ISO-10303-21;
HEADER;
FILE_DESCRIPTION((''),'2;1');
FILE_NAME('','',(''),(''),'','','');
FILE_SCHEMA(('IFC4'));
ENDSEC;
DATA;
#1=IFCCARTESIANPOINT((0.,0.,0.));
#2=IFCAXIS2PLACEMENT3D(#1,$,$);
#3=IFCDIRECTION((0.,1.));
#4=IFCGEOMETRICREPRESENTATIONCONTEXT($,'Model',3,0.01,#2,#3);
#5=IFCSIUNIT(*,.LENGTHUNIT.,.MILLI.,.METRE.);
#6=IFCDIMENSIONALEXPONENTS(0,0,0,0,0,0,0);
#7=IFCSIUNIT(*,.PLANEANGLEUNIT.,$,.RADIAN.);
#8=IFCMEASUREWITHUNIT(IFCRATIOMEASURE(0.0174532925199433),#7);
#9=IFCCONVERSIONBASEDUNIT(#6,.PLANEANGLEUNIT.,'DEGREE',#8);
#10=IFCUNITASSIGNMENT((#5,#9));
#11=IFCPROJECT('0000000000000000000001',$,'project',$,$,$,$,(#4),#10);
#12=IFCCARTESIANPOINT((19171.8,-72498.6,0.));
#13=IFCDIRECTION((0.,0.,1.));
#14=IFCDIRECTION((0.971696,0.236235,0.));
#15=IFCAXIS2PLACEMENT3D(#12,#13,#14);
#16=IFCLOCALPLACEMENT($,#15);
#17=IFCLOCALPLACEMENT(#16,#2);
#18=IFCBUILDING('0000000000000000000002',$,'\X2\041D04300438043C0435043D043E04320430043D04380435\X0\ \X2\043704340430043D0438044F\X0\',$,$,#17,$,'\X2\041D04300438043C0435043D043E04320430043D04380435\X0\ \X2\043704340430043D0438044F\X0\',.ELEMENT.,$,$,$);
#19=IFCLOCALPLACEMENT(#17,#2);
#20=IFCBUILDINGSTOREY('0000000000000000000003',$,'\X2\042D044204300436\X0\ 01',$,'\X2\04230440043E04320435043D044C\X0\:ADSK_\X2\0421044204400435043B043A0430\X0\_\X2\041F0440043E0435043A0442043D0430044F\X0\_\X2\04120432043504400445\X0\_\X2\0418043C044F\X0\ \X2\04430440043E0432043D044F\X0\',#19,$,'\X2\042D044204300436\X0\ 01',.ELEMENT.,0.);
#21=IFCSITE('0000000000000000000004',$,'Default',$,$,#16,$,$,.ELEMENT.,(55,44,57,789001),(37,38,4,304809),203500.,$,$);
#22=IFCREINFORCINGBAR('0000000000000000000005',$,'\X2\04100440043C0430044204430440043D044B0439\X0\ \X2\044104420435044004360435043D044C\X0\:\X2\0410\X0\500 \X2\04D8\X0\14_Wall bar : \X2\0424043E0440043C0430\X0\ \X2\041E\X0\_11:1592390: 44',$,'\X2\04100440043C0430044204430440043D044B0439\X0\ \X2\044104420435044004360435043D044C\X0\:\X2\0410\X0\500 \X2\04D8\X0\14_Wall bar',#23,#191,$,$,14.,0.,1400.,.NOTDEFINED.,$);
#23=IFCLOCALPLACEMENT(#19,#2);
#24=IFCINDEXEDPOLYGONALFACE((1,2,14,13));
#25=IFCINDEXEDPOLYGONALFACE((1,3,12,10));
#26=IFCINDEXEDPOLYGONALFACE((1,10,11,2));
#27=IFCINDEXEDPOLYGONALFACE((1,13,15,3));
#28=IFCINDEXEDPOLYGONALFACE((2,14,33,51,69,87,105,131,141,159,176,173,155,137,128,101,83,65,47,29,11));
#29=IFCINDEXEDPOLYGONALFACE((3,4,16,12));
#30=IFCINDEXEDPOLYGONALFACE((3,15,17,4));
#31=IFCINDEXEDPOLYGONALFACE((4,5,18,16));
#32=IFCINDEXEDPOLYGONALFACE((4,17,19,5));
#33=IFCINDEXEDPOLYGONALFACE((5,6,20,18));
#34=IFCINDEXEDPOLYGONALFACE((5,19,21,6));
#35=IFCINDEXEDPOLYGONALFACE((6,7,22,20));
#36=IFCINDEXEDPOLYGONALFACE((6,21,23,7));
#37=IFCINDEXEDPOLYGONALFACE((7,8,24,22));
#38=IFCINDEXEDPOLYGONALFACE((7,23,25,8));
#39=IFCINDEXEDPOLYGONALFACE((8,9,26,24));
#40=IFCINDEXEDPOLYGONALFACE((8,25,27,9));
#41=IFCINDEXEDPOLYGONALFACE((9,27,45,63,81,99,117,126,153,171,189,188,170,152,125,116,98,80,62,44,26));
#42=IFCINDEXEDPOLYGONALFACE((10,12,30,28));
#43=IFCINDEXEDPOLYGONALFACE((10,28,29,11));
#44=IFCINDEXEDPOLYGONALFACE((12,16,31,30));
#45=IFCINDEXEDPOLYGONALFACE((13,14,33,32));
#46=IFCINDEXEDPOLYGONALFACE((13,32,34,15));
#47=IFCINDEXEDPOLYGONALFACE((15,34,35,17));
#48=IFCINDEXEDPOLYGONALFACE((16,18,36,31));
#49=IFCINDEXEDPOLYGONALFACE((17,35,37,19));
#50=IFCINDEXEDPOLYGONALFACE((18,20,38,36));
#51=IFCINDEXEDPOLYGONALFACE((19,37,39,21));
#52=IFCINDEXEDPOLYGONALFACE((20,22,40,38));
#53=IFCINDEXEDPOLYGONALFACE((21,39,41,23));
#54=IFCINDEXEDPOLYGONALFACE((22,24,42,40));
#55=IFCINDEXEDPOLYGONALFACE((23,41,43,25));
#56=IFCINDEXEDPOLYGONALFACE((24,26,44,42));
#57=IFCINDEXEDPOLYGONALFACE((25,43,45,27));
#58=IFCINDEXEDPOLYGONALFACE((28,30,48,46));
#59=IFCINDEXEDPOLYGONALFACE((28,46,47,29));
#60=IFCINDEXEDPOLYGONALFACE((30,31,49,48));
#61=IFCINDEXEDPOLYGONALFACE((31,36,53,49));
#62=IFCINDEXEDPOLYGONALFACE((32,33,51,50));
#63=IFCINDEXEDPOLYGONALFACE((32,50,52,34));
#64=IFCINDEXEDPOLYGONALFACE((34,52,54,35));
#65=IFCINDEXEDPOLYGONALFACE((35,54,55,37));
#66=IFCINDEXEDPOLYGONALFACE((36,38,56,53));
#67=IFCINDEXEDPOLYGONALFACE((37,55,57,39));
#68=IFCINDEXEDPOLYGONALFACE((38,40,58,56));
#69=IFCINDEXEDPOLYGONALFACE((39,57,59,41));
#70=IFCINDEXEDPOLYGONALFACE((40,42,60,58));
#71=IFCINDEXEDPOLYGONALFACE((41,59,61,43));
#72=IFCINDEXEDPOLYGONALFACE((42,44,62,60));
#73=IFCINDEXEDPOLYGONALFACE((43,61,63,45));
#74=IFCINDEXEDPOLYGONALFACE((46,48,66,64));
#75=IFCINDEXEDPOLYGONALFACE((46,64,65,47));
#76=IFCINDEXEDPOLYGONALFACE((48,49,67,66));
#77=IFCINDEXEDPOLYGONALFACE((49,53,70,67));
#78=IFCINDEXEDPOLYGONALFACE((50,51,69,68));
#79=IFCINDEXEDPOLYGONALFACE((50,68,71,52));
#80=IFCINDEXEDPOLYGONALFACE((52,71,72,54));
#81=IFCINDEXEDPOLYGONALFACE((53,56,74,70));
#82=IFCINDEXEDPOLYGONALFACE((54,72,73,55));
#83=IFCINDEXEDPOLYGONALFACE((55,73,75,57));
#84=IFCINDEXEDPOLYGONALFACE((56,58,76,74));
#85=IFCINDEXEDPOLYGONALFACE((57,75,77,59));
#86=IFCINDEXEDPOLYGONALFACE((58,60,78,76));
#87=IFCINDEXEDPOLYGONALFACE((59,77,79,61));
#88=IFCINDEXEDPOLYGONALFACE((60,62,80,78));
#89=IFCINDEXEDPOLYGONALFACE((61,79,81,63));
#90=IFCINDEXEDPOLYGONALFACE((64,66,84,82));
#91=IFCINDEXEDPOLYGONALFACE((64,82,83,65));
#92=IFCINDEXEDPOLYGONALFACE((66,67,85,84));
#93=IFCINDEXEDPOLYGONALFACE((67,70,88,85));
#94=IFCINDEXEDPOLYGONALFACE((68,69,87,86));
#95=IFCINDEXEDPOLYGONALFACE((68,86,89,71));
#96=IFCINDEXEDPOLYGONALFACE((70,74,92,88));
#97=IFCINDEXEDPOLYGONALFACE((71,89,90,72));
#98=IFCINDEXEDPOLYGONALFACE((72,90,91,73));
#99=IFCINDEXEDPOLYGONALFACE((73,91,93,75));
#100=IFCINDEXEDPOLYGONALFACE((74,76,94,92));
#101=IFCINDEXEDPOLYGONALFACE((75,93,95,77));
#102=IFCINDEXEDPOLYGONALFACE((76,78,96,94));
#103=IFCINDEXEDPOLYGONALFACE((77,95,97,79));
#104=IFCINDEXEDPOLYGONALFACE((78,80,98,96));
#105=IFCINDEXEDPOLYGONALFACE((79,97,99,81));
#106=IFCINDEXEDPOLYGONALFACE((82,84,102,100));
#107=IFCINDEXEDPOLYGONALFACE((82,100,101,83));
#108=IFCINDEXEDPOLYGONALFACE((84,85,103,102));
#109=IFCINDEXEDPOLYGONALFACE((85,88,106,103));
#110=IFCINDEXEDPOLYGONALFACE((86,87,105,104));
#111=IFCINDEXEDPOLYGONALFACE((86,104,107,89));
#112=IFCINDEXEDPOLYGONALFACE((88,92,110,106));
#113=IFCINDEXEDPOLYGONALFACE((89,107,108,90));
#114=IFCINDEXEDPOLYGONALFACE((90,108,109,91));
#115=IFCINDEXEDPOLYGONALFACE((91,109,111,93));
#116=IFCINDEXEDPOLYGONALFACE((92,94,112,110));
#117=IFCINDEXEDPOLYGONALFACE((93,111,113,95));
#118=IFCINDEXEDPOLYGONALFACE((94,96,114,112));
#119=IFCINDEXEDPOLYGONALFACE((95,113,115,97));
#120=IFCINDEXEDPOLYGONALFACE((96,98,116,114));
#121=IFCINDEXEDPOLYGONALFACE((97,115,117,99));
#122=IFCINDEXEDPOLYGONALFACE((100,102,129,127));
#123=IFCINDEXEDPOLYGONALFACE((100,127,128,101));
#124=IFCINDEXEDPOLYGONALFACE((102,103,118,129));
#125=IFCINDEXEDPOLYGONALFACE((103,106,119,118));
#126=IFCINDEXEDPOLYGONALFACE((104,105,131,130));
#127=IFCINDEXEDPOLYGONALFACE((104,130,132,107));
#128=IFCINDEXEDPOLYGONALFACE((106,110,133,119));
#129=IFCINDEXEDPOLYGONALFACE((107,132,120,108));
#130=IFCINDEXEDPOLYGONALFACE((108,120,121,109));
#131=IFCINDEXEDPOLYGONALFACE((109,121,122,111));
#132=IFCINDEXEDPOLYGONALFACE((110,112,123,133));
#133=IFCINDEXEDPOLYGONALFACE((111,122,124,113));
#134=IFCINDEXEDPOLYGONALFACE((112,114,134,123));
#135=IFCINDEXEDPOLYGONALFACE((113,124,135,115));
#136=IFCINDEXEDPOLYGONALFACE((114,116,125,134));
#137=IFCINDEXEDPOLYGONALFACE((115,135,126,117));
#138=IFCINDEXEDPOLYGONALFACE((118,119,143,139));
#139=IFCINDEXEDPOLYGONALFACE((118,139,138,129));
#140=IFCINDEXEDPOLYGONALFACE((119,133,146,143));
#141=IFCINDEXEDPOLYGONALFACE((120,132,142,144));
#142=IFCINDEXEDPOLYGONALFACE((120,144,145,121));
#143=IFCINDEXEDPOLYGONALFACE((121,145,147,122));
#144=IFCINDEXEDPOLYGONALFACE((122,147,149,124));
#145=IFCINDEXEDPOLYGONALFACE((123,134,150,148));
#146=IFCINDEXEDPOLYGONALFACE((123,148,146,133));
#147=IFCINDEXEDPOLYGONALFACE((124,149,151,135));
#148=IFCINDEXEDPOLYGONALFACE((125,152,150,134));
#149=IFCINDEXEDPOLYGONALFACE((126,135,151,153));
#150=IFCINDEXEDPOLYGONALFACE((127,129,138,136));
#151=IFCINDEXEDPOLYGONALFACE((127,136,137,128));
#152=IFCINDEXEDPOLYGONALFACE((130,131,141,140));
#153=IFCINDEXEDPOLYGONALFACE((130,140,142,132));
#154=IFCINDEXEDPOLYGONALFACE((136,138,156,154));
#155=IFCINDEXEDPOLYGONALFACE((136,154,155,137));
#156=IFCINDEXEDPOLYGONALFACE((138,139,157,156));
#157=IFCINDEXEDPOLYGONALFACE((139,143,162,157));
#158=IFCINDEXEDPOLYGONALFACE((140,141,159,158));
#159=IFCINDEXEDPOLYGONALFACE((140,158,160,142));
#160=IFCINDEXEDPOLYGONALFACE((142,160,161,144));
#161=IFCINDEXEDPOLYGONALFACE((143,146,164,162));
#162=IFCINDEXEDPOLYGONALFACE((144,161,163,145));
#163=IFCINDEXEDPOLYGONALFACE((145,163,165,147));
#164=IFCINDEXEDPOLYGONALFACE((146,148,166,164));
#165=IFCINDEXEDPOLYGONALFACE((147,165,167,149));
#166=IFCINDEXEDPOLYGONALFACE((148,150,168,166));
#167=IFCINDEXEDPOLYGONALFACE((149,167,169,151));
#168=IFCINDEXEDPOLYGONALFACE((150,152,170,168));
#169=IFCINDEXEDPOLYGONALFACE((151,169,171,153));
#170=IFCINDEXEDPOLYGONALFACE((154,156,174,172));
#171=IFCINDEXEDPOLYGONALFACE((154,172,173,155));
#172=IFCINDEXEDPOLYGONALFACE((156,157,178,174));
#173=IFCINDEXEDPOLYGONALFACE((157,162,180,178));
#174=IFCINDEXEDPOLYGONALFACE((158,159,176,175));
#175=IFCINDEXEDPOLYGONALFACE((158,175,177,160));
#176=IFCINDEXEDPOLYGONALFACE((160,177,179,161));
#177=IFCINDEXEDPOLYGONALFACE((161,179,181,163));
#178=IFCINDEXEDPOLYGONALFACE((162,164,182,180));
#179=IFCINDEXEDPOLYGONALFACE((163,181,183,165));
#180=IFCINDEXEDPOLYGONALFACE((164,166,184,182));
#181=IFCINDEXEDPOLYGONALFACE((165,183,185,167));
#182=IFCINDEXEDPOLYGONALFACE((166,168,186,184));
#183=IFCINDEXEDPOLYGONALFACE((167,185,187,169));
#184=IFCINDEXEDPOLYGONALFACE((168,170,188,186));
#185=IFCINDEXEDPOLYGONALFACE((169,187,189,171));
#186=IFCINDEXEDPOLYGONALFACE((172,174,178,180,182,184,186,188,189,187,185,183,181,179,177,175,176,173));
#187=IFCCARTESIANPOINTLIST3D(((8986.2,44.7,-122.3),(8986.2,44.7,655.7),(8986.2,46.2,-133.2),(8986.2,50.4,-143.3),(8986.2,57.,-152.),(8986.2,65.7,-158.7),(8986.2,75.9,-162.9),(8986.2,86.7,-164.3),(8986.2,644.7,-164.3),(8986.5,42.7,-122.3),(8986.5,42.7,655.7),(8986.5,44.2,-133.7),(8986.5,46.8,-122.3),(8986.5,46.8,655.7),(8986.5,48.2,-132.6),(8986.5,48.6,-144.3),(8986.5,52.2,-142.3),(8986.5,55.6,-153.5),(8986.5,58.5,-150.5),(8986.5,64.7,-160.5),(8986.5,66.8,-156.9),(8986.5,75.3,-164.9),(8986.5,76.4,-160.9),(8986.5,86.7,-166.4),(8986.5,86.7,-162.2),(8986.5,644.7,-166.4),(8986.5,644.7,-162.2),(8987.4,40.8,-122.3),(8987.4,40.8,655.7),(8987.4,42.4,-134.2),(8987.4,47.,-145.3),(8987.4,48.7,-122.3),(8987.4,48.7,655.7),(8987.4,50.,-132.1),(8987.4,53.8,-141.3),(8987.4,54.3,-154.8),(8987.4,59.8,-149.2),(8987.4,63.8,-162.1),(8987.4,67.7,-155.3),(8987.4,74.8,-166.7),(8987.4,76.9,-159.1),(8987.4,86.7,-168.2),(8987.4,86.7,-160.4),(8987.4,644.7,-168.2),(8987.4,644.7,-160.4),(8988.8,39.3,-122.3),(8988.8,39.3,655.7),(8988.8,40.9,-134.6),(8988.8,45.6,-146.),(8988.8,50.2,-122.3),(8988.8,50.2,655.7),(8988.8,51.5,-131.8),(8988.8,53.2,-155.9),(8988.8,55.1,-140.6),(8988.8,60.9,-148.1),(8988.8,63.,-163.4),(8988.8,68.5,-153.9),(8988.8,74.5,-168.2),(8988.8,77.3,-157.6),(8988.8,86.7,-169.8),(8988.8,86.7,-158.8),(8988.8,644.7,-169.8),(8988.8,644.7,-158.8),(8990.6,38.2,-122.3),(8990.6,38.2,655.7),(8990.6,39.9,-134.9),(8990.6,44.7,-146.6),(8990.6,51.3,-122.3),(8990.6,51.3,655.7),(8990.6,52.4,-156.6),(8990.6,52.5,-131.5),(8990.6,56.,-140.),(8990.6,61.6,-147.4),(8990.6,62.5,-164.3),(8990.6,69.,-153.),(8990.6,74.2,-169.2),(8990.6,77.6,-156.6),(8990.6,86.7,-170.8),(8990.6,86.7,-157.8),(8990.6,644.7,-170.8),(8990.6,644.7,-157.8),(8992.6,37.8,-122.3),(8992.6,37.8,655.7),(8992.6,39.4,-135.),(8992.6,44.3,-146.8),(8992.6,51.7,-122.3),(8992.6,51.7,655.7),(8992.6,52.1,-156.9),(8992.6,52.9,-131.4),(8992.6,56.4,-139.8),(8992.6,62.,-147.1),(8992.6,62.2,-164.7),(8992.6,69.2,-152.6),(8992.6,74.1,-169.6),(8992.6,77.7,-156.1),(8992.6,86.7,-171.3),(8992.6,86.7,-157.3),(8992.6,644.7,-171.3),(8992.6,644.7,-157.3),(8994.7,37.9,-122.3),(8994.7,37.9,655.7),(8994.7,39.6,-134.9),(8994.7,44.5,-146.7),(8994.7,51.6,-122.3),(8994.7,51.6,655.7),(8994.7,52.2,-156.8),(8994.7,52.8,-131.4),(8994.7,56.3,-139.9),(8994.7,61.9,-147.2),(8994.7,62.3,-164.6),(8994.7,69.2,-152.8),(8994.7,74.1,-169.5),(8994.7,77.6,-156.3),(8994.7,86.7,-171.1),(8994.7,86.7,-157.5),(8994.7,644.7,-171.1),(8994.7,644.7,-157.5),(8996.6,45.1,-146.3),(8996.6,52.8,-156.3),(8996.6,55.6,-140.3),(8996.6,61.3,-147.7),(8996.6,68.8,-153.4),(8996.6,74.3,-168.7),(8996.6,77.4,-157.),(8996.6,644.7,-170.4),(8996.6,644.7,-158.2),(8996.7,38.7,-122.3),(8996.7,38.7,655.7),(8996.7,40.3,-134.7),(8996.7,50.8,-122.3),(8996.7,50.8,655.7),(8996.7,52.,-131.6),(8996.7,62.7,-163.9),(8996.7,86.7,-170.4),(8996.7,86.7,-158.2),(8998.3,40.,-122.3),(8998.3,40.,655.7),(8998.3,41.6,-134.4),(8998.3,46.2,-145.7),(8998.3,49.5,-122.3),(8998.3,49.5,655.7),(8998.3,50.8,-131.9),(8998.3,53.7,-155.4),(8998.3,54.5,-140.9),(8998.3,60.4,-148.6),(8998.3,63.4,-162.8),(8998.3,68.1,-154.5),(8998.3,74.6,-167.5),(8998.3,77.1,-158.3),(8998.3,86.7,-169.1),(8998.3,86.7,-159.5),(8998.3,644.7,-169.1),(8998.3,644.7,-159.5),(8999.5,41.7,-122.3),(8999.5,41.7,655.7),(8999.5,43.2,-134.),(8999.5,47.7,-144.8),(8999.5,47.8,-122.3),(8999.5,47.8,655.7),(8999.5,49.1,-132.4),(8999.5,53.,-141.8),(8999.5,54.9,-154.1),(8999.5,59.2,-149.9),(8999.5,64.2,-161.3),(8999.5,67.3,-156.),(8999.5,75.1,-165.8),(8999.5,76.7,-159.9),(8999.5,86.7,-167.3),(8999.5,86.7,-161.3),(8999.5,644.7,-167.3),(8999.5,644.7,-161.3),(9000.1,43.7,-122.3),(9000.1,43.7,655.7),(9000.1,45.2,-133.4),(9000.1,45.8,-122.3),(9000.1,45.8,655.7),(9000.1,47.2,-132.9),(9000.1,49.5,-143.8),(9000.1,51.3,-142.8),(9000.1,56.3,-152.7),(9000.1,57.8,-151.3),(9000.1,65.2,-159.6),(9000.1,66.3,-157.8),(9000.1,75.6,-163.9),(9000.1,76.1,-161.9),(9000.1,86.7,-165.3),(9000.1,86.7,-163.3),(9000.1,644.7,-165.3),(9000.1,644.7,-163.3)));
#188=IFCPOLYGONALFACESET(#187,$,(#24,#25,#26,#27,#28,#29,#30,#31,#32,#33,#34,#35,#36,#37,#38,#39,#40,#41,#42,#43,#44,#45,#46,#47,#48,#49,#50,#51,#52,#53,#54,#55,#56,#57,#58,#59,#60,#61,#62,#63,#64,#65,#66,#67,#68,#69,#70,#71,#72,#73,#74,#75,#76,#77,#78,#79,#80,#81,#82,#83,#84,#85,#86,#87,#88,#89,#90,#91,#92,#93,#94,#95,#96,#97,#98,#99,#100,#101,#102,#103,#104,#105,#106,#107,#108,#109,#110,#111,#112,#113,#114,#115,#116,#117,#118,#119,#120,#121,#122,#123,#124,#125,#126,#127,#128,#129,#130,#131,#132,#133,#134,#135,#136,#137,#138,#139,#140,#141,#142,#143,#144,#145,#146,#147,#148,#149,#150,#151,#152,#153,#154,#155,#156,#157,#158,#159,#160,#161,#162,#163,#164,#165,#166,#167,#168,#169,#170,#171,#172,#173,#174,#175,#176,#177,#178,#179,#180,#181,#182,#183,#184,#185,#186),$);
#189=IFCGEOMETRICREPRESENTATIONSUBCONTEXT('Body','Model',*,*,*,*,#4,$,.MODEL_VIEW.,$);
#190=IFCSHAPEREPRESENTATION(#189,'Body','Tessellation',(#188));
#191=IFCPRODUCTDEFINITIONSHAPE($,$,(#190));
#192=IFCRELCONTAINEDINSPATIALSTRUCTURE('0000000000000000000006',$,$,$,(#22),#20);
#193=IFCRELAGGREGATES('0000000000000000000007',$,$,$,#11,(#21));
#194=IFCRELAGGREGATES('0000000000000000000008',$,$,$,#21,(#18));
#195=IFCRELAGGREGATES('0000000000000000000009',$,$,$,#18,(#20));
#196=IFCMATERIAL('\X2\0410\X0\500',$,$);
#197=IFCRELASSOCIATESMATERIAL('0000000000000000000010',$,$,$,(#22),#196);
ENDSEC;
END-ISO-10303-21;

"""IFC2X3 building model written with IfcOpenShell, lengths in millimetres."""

from ifc_helpers import new_model, entity, si_unit, converted_unit, direction, frame, origin, place, context, subcontext, project, spatial, material, element, save


model = new_model("IFC2X3")

# Units and contexts
model_context = context("Model", 3, precision=0.01, world=origin(), true_north=direction((0.0, 1.0)))
body_context = subcontext(model_context, "Body", "Model", "MODEL_VIEW")
ifc_project = project(units=[si_unit("LENGTHUNIT", "METRE", prefix="MILLI"), converted_unit("PLANEANGLEUNIT", "DEGREE", entity("IfcRatioMeasure", 0.0174532925199433), si_unit("PLANEANGLEUNIT", "RADIAN"), dimensions=[0, 0, 0, 0, 0, 0, 0])], contexts=[model_context])

# Site, building, storey
site_placement = place(None, frame((19171.8, -72498.6, 0.0), z_axis=(0.0, 0.0, 1.0), x_axis=(0.971696, 0.236235, 0.0)))
site = spatial("IfcSite", under=ifc_project, at=site_placement, Name="Default", CompositionType="ELEMENT", RefLatitude=(55, 44, 57, 789001), RefLongitude=(37, 38, 4, 304809), RefElevation=203500.0)
building_placement = place(site_placement, origin())
building = spatial("IfcBuilding", under=site, at=building_placement, Name="Наименование здания", LongName="Наименование здания", CompositionType="ELEMENT")
storey_placement = place(building_placement, origin())
storey = spatial("IfcBuildingStorey", under=building, at=storey_placement, Name="Этаж 01", ObjectType="Уровень:ADSK_Стрелка_Проектная_Вверх_Имя уровня", LongName="Этаж 01", CompositionType="ELEMENT", Elevation=0.0)

# Reinforcing bar
ifc_material = material(Name="А500")
placement = place(storey_placement, origin())
element("IfcReinforcingBar", 1, at=placement, inside=storey, material=ifc_material, Name="Арматурный стержень:А500 Ә14_Wall bar : Форма О_11:1592390: 44", ObjectType="Арматурный стержень:А500 Ә14_Wall bar", BarLength=1400.0, BarRole="NOTDEFINED", CrossSectionArea=0.0, NominalDiameter=14.0, context=body_context, shape_type="AdvancedSweptSolid", body=[
    entity("IfcSweptDiskSolid", entity("IfcCompositeCurve", [entity("IfcCompositeCurveSegment", "CONTINUOUS", True, entity("IfcPolyline", [entity("IfcCartesianPoint", [8993.1, 44.7, 655.7]), entity("IfcCartesianPoint", [8993.1, 44.7, -122.3])])), entity("IfcCompositeCurveSegment", "CONTINUOUS", True, entity("IfcTrimmedCurve", entity("IfcCircle", entity("IfcAxis2Placement3D", entity("IfcCartesianPoint", [8993.1, 86.7, -122.3]), entity("IfcDirection", [1.0, 0.0, 0.0]), entity("IfcDirection", [0.0, 0.0, -1.0])), 42.0), [entity("IfcParameterValue", 270.0)], [entity("IfcParameterValue", 360.0)], True, "PARAMETER")), entity("IfcCompositeCurveSegment", "CONTINUOUS", True, entity("IfcPolyline", [entity("IfcCartesianPoint", [8993.1, 86.7, -164.3]), entity("IfcCartesianPoint", [8993.1, 644.7, -164.3])]))], False), 7.0, None, 0.0, 92.0),
])

save(model, "model.ifc")
